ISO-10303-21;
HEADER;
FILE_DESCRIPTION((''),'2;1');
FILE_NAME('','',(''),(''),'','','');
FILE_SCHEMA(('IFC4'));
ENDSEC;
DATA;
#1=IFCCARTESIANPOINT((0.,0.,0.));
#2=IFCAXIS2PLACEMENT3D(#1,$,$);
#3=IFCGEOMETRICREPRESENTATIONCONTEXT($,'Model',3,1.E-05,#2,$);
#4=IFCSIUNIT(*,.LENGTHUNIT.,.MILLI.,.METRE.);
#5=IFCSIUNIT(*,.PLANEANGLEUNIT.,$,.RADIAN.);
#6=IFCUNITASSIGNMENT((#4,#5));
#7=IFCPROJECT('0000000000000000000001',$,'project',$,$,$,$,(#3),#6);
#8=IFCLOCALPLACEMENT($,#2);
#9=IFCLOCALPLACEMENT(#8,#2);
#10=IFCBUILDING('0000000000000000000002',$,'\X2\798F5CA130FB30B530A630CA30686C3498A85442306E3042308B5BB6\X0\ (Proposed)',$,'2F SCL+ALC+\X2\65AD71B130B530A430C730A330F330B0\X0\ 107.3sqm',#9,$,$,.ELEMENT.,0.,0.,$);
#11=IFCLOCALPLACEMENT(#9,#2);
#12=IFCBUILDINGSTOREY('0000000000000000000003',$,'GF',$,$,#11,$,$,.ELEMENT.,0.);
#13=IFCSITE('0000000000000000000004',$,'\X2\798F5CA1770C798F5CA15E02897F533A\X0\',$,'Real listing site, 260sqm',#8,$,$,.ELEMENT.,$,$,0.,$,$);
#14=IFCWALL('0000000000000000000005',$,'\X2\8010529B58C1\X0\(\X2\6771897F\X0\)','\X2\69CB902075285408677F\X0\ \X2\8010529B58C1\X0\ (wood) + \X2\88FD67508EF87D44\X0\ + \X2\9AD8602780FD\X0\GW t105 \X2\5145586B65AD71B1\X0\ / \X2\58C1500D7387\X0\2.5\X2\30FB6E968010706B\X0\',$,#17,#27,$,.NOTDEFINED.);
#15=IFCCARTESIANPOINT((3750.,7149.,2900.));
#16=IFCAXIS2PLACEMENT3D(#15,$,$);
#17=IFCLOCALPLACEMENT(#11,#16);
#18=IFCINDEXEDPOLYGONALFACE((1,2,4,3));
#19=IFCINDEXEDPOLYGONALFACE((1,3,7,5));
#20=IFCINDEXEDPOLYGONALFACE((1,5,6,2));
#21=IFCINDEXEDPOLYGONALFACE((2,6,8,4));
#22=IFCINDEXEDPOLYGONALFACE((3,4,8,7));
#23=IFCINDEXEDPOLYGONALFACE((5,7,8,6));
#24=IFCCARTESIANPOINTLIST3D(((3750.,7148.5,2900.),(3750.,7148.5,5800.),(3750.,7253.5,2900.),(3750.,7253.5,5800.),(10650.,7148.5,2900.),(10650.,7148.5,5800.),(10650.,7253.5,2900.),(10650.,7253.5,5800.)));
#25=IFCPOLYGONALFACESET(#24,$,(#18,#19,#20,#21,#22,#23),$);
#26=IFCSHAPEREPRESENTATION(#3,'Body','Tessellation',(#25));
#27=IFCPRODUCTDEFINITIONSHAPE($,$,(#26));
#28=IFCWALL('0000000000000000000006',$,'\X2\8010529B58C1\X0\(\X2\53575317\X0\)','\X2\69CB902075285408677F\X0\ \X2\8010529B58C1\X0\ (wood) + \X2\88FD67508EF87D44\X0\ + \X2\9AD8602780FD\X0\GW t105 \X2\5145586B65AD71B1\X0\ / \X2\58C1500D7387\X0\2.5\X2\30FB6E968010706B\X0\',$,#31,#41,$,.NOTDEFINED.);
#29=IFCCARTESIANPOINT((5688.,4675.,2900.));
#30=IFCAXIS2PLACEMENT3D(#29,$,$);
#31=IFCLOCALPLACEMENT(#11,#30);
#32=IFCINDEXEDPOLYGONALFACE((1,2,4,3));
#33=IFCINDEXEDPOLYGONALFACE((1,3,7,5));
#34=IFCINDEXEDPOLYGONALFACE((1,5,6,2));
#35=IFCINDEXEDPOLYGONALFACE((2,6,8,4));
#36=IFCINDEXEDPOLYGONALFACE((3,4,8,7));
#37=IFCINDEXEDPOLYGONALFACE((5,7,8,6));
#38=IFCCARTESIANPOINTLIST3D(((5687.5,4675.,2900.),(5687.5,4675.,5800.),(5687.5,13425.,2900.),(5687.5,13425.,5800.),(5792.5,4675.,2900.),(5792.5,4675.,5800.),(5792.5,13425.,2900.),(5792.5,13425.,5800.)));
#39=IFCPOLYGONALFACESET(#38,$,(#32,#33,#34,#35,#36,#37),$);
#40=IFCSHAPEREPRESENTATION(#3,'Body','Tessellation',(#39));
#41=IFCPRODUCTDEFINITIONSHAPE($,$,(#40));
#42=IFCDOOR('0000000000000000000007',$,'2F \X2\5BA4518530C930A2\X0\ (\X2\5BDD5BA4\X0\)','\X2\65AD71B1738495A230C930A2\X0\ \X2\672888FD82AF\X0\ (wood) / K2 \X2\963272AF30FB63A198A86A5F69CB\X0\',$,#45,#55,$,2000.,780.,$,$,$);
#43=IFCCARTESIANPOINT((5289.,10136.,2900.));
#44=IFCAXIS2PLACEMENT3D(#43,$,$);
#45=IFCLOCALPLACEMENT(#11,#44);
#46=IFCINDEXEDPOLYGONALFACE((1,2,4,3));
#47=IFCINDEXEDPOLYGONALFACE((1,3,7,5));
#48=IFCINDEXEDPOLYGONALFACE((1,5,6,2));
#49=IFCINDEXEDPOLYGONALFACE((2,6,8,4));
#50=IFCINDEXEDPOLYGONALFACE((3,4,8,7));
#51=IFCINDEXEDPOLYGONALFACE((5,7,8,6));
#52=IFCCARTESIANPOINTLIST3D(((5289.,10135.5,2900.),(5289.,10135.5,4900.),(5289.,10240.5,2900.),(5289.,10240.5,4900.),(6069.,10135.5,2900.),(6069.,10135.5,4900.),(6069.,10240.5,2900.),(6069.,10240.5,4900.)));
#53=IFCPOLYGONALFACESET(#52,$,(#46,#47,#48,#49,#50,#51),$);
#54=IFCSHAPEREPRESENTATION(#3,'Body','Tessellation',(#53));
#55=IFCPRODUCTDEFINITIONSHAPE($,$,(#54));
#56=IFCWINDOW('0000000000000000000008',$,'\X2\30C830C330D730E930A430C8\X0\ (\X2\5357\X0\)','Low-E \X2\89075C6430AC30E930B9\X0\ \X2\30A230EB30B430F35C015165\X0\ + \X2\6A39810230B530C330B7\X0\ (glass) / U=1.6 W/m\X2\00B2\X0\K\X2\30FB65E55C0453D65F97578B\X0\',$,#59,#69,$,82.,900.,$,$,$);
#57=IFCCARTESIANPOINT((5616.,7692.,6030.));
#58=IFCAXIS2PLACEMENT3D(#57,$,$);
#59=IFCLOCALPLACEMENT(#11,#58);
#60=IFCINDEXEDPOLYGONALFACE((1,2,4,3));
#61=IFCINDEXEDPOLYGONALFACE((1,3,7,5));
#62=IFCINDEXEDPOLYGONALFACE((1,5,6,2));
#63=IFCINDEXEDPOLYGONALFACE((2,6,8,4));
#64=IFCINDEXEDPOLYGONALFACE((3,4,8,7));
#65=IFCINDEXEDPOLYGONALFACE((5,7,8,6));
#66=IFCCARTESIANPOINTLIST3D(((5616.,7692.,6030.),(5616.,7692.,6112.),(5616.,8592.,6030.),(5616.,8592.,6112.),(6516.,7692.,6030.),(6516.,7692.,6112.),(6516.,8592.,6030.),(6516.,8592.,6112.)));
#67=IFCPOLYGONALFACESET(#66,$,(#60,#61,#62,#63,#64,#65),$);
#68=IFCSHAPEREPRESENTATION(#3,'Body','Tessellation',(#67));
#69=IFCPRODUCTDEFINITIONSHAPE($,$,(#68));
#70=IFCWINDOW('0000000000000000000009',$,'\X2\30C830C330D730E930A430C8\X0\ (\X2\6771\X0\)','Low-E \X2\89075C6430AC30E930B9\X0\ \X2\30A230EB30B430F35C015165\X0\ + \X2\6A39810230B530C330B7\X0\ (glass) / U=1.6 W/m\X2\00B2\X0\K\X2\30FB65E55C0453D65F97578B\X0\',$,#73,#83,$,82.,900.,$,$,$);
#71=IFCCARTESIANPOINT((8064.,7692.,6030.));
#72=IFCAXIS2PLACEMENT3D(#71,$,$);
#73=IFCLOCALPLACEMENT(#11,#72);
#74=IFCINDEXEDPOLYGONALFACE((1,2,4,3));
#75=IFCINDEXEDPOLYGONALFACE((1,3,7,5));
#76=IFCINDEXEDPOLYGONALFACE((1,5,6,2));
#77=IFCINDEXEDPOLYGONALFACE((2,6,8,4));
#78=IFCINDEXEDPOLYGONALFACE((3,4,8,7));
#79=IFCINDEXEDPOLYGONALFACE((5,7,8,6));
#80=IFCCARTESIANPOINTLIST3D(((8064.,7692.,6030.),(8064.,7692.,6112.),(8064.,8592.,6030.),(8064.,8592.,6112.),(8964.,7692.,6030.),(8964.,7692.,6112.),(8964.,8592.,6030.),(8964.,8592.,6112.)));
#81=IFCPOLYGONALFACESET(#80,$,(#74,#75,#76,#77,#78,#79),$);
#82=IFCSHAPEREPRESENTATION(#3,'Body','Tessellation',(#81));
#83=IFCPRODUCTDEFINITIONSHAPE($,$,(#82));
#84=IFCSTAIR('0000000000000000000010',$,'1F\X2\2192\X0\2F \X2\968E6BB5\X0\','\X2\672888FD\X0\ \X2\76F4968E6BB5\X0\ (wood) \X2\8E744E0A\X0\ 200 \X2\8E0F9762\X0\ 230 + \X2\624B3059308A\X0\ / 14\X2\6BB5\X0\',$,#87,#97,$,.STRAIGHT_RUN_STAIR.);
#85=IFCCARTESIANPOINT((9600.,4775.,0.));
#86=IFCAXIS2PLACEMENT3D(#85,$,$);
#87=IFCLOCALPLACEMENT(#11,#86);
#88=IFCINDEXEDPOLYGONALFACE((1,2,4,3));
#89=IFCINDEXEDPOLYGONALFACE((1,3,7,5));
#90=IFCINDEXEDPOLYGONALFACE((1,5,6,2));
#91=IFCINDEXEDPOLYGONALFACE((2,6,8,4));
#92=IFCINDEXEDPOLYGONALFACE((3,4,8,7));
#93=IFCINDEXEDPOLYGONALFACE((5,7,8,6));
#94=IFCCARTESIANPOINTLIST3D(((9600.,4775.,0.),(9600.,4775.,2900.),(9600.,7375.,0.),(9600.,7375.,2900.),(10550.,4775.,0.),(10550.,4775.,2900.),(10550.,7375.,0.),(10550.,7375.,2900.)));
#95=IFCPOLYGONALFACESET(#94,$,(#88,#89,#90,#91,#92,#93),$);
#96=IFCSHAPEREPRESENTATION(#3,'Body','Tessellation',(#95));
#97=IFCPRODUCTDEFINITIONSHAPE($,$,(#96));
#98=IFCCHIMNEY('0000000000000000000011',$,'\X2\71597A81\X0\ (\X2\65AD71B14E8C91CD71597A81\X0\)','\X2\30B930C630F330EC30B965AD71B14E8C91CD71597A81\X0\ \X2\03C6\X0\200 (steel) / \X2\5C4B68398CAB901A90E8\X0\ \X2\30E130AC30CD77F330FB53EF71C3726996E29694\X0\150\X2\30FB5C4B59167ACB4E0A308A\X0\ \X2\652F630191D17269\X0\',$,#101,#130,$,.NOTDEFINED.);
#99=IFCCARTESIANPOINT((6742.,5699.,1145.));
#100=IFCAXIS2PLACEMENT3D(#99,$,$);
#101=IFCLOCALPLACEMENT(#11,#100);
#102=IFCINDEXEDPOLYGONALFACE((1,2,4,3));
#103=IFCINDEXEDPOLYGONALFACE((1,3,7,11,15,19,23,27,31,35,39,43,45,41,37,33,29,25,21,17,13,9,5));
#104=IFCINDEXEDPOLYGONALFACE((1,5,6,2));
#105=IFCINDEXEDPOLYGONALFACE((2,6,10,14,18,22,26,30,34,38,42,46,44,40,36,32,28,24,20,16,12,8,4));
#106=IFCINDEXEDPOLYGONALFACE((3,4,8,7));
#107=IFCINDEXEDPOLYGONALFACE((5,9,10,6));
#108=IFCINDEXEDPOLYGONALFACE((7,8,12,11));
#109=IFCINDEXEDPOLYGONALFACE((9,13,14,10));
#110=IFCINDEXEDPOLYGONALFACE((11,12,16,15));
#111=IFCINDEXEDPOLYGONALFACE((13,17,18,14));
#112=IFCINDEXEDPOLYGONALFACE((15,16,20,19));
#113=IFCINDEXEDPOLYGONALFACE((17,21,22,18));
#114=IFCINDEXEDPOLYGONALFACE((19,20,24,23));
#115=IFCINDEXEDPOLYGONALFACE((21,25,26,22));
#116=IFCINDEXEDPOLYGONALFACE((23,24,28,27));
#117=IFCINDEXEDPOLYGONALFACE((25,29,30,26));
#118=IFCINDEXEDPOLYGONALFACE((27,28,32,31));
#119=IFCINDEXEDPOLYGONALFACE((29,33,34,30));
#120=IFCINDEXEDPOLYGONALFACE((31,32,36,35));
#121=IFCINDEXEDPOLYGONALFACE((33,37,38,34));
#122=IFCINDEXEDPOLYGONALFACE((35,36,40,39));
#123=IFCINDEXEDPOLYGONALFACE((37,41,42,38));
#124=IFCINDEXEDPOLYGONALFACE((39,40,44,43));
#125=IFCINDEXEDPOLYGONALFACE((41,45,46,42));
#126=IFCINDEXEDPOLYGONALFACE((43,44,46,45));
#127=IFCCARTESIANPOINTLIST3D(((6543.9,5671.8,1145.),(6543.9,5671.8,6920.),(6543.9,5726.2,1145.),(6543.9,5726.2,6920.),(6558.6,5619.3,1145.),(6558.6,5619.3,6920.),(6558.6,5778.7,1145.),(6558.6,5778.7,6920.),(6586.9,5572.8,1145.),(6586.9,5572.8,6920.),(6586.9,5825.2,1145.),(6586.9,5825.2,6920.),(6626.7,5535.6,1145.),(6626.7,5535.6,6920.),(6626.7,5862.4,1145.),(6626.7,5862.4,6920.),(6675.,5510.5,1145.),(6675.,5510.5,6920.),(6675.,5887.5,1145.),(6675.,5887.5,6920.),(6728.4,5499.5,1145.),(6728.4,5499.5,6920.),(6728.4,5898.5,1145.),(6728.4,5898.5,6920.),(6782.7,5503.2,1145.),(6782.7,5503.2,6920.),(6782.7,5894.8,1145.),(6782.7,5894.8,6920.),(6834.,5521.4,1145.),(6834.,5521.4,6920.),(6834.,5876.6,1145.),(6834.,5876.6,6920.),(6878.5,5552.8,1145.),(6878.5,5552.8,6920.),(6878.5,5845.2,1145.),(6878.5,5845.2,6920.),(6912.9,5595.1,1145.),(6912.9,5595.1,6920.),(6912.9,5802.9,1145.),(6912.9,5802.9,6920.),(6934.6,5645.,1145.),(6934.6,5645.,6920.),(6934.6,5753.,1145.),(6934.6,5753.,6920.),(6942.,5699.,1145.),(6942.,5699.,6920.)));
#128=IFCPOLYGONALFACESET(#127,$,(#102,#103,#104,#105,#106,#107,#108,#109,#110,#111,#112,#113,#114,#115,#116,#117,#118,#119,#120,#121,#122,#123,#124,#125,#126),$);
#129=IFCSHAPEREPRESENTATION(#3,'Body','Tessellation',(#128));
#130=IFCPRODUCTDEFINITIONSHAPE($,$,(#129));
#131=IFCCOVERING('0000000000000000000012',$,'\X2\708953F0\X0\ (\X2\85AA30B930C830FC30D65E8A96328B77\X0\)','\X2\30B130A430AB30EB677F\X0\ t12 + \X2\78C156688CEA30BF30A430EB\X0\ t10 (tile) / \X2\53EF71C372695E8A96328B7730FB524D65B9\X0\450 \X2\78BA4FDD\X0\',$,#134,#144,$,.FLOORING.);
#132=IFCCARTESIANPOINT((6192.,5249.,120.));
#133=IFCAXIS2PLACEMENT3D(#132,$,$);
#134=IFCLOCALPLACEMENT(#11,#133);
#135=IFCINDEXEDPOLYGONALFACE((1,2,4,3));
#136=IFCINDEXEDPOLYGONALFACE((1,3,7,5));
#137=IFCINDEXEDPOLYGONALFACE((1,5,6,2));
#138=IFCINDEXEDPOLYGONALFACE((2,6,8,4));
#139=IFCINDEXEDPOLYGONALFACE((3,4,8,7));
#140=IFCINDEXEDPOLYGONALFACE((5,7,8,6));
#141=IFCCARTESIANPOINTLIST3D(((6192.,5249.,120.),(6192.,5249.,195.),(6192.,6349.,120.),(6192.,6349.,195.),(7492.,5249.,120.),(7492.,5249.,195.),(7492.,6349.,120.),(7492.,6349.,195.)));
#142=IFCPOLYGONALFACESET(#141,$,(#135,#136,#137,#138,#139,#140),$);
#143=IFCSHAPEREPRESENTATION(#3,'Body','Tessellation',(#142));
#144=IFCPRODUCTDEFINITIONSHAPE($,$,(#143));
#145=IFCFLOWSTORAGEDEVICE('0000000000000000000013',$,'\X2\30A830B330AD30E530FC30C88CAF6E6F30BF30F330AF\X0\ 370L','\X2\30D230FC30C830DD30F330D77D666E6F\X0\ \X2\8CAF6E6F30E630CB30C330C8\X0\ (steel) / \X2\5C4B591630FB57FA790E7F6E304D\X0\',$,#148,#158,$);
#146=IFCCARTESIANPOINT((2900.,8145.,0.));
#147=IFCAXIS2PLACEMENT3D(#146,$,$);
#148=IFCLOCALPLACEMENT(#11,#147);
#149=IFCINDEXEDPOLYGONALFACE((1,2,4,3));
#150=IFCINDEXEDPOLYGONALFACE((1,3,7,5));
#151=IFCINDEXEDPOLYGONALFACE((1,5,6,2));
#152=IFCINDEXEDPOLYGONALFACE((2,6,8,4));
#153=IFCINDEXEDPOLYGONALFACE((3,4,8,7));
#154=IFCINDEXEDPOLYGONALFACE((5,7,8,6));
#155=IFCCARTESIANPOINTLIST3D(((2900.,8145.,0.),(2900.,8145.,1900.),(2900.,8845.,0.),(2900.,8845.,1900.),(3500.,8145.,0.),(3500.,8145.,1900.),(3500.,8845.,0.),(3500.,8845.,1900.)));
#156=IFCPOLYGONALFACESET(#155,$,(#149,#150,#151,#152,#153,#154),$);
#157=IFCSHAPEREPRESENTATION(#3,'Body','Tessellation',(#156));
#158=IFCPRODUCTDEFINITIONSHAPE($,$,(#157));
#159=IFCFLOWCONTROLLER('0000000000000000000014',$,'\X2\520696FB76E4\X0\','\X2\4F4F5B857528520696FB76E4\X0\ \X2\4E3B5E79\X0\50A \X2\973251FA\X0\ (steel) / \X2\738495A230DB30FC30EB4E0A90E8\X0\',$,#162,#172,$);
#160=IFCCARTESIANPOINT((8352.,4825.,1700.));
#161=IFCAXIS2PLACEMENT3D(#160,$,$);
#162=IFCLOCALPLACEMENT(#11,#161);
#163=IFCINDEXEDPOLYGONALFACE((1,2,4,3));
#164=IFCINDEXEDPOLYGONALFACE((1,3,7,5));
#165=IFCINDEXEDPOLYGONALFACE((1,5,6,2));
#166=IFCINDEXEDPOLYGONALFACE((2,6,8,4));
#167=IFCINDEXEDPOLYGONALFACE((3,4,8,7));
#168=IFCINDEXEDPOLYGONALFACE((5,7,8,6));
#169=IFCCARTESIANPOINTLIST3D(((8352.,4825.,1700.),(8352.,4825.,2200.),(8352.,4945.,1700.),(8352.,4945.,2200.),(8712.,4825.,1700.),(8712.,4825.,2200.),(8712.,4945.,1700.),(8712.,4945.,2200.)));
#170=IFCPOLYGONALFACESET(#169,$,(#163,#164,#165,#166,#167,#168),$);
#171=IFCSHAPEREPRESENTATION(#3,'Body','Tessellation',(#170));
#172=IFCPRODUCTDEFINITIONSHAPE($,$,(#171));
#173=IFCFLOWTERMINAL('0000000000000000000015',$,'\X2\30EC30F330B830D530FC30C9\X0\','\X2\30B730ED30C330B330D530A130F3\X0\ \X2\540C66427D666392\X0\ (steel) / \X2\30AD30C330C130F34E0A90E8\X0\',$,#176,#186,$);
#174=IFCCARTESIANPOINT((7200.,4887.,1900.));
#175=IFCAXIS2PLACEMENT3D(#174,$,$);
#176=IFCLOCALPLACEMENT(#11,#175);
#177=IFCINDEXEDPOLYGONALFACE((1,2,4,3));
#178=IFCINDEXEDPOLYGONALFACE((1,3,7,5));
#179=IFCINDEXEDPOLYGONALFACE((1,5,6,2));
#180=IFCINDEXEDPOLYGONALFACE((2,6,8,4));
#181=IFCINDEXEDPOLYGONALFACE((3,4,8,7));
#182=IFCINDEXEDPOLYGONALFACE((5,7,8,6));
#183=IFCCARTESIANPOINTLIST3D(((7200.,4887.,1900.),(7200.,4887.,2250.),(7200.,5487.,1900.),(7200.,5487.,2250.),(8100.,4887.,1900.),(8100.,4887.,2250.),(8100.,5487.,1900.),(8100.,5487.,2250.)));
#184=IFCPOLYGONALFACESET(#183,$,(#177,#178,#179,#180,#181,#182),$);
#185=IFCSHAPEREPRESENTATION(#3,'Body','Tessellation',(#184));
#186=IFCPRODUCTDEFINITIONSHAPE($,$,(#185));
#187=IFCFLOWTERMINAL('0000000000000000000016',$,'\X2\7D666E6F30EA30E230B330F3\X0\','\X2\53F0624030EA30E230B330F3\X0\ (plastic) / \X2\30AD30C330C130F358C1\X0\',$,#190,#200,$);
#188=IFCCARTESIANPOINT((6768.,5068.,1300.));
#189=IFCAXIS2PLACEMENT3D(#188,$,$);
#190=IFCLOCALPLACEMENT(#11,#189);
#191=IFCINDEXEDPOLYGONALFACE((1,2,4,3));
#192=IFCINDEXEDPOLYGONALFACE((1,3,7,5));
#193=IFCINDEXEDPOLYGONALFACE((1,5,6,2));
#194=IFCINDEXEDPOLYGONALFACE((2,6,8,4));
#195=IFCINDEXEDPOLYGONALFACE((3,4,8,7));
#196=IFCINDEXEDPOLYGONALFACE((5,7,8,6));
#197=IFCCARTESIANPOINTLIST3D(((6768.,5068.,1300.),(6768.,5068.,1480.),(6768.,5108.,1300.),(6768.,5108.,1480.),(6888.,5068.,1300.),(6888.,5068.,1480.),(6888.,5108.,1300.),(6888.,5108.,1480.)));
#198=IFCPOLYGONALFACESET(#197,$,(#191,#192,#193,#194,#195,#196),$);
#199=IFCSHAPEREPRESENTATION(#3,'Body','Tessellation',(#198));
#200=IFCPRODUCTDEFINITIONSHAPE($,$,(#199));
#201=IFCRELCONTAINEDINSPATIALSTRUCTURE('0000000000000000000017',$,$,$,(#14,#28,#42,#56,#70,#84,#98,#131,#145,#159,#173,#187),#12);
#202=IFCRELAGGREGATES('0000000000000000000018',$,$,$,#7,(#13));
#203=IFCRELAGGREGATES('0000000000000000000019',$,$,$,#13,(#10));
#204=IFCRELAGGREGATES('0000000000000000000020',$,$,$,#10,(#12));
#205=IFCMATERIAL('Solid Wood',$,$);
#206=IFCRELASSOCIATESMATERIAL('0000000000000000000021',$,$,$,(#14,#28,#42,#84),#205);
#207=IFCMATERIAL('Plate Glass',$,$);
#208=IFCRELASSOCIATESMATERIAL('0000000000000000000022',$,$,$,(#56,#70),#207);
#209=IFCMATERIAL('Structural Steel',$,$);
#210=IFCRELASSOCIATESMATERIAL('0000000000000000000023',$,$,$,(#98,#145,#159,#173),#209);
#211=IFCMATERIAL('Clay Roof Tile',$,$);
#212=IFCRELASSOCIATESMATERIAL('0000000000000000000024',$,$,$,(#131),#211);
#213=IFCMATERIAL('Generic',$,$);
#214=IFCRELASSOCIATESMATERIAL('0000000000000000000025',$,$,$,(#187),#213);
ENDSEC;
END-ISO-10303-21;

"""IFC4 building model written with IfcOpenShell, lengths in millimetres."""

from ifc_helpers import new_model, si_unit, frame, frame_2d, origin, origin_2d, place, context, project, spatial, rectangle, circle, extrude, material, element, fill, save


model = new_model("IFC4")

# Units and contexts
model_context = context("Model", 3, precision=1e-05, world=origin())
ifc_project = project(units=[si_unit("LENGTHUNIT", "METRE", prefix="MILLI"), si_unit("PLANEANGLEUNIT", "RADIAN")], contexts=[model_context])

# Site, building, storey
site_placement = place(None, origin())
site = spatial("IfcSite", under=ifc_project, at=site_placement, Name="福岡県福岡市西区", ObjectType="Real listing site, 260sqm", CompositionType="ELEMENT", RefElevation=0.0)
building_placement = place(site_placement, origin())
building = spatial("IfcBuilding", under=site, at=building_placement, Name="福岡・サウナと水風呂のある家 (Proposed)", ObjectType="2F SCL+ALC+断熱サイディング 107.3sqm", CompositionType="ELEMENT", ElevationOfRefHeight=0.0, ElevationOfTerrain=0.0)
storey_placement = place(building_placement, origin())
storey = spatial("IfcBuildingStorey", under=building, at=storey_placement, Name="GF", CompositionType="ELEMENT", Elevation=0.0)

# Shared definitions
ifc_material_1 = material(Name="Solid Wood")

# Wall
wall_1_placement = place(storey_placement, frame((3750.0, 7149.0, 2900.0)))
element("IfcWall", 1, at=wall_1_placement, inside=storey, material=ifc_material_1, Name="耐力壁(東西)", Description="構造用合板 耐力壁 (wood) + 製材軸組 + 高性能GW t105 充填断熱 / 壁倍率2.5・準耐火", PredefinedType="NOTDEFINED", context=model_context, shape_type="SweptSolid", body=[
    extrude(rectangle(XDim=6900.0, YDim=105.0, at=frame_2d((3450.0, 52.0))), frame((3750.0, 7149.0, 2900.0)), (0.0, 0.0, 1.0), 2900.0),
])

# Wall, opening, door
wall_2_placement = place(storey_placement, frame((5688.0, 4675.0, 2900.0)))
wall_2 = element("IfcWall", 2, at=wall_2_placement, inside=storey, material=ifc_material_1, Name="耐力壁(南北)", Description="構造用合板 耐力壁 (wood) + 製材軸組 + 高性能GW t105 充填断熱 / 壁倍率2.5・準耐火", PredefinedType="NOTDEFINED", context=model_context, shape_type="SweptSolid", body=[
    extrude(rectangle(XDim=105.0, YDim=8750.0, at=frame_2d((52.0, 4375.0))), frame((5688.0, 4675.0, 2900.0)), (0.0, 0.0, 1.0), 2900.0),
])
opening_placement = place(storey_placement, frame((5289.0, 10136.0, 2900.0)))
opening = element("IfcOpeningElement", 3, at=opening_placement, cuts=wall_2, PredefinedType="NOTDEFINED", context=model_context, shape_type="SweptSolid", body=[
    extrude(rectangle(XDim=780.0, YDim=105.0, at=frame_2d((390.0, 52.0))), frame((5289.0, 10136.0, 2900.0)), (0.0, 0.0, 1.0), 2000.0),
])
door_placement = place(storey_placement, frame((5289.0, 10136.0, 2900.0)))
door = element("IfcDoor", 4, at=door_placement, inside=storey, material=ifc_material_1, Name="2F 室内ドア (寝室)", Description="断熱玄関ドア 木製芯 (wood) / K2 防犯・採風機構", OverallHeight=2000.0, OverallWidth=780.0, context=model_context, shape_type="SweptSolid", body=[
    extrude(rectangle(XDim=780.0, YDim=105.0, at=frame_2d((390.0, 52.0))), frame((5289.0, 10136.0, 2900.0)), (0.0, 0.0, 1.0), 2000.0),
])
fill(opening, door)

# Windows
ifc_material_2 = material(Name="Plate Glass")
window_1_placement = place(storey_placement, frame((5616.0, 7692.0, 6030.0)))
element("IfcWindow", 5, at=window_1_placement, inside=storey, material=ifc_material_2, Name="トップライト (南)", Description="Low-E 複層ガラス アルゴン封入 + 樹脂サッシ (glass) / U=1.6 W/m²K・日射取得型", OverallHeight=82.0, OverallWidth=900.0, context=model_context, shape_type="SweptSolid", body=[
    extrude(rectangle(XDim=900.0, YDim=900.0, at=frame_2d((450.0, 450.0))), frame((5616.0, 7692.0, 6030.0)), (0.0, 0.0, 1.0), 82.0),
])
window_2_placement = place(storey_placement, frame((8064.0, 7692.0, 6030.0)))
element("IfcWindow", 6, at=window_2_placement, inside=storey, material=ifc_material_2, Name="トップライト (東)", Description="Low-E 複層ガラス アルゴン封入 + 樹脂サッシ (glass) / U=1.6 W/m²K・日射取得型", OverallHeight=82.0, OverallWidth=900.0, context=model_context, shape_type="SweptSolid", body=[
    extrude(rectangle(XDim=900.0, YDim=900.0, at=frame_2d((450.0, 450.0))), frame((8064.0, 7692.0, 6030.0)), (0.0, 0.0, 1.0), 82.0),
])

# Stair
stair_placement = place(storey_placement, frame((9600.0, 4775.0, 0.0)))
element("IfcStair", 7, at=stair_placement, inside=storey, material=ifc_material_1, Name="1F→2F 階段", Description="木製 直階段 (wood) 蹴上 200 踏面 230 + 手すり / 14段", PredefinedType="STRAIGHT_RUN_STAIR", context=model_context, shape_type="SweptSolid", body=[
    extrude(rectangle(XDim=950.0, YDim=2600.0, at=frame_2d((475.0, 1300.0))), frame((9600.0, 4775.0, 0.0)), (0.0, 0.0, 1.0), 2900.0),
])

# Chimney
ifc_material_3 = material(Name="Structural Steel")
chimney_placement = place(storey_placement, frame((6742.0, 5699.0, 1145.0)))
element("IfcChimney", 8, at=chimney_placement, inside=storey, material=ifc_material_3, Name="煙突 (断熱二重煙突)", Description="ステンレス断熱二重煙突 φ200 (steel) / 屋根貫通部 メガネ石・可燃物離隔150・屋外立上り 支持金物", PredefinedType="NOTDEFINED", context=model_context, shape_type="SweptSolid", body=[
    extrude(circle(Radius=200.0, at=origin_2d()), frame((6742.0, 5699.0, 1145.0)), (0.0, 0.0, 1.0), 5775.0),
])

# Covering
ifc_material_4 = material(Name="Clay Roof Tile")
covering_placement = place(storey_placement, frame((6192.0, 5249.0, 120.0)))
element("IfcCovering", 9, at=covering_placement, inside=storey, material=ifc_material_4, Name="炉台 (薪ストーブ床防護)", Description="ケイカル板 t12 + 磁器質タイル t10 (tile) / 可燃物床防護・前方450 確保", PredefinedType="FLOORING", context=model_context, shape_type="SweptSolid", body=[
    extrude(rectangle(XDim=1300.0, YDim=1100.0, at=frame_2d((650.0, 550.0))), frame((6192.0, 5249.0, 120.0)), (0.0, 0.0, 1.0), 75.0),
])

# Flow storage device
flow_storage_device_placement = place(storey_placement, frame((2900.0, 8145.0, 0.0)))
element("IfcFlowStorageDevice", 10, at=flow_storage_device_placement, inside=storey, material=ifc_material_3, Name="エコキュート貯湯タンク 370L", Description="ヒートポンプ給湯 貯湯ユニット (steel) / 屋外・基礎置き", context=model_context, shape_type="SweptSolid", body=[
    extrude(rectangle(XDim=600.0, YDim=700.0, at=frame_2d((300.0, 350.0))), frame((2900.0, 8145.0, 0.0)), (0.0, 0.0, 1.0), 1900.0),
])

# Flow controller
flow_controller_placement = place(storey_placement, frame((8352.0, 4825.0, 1700.0)))
element("IfcFlowController", 11, at=flow_controller_placement, inside=storey, material=ifc_material_3, Name="分電盤", Description="住宅用分電盤 主幹50A 露出 (steel) / 玄関ホール上部", context=model_context, shape_type="SweptSolid", body=[
    extrude(rectangle(XDim=360.0, YDim=120.0, at=frame_2d((180.0, 60.0))), frame((8352.0, 4825.0, 1700.0)), (0.0, 0.0, 1.0), 500.0),
])

# Flow terminals
flow_terminal_1_placement = place(storey_placement, frame((7200.0, 4887.0, 1900.0)))
element("IfcFlowTerminal", 12, at=flow_terminal_1_placement, inside=storey, material=ifc_material_3, Name="レンジフード", Description="シロッコファン 同時給排 (steel) / キッチン上部", context=model_context, shape_type="SweptSolid", body=[
    extrude(rectangle(XDim=900.0, YDim=600.0, at=frame_2d((450.0, 300.0))), frame((7200.0, 4887.0, 1900.0)), (0.0, 0.0, 1.0), 350.0),
])
ifc_material_5 = material(Name="Generic")
flow_terminal_2_placement = place(storey_placement, frame((6768.0, 5068.0, 1300.0)))
element("IfcFlowTerminal", 13, at=flow_terminal_2_placement, inside=storey, material=ifc_material_5, Name="給湯リモコン", Description="台所リモコン (plastic) / キッチン壁", context=model_context, shape_type="SweptSolid", body=[
    extrude(rectangle(XDim=120.0, YDim=40.0, at=frame_2d((60.0, 20.0))), frame((6768.0, 5068.0, 1300.0)), (0.0, 0.0, 1.0), 180.0),
])

save(model, "model.ifc")
